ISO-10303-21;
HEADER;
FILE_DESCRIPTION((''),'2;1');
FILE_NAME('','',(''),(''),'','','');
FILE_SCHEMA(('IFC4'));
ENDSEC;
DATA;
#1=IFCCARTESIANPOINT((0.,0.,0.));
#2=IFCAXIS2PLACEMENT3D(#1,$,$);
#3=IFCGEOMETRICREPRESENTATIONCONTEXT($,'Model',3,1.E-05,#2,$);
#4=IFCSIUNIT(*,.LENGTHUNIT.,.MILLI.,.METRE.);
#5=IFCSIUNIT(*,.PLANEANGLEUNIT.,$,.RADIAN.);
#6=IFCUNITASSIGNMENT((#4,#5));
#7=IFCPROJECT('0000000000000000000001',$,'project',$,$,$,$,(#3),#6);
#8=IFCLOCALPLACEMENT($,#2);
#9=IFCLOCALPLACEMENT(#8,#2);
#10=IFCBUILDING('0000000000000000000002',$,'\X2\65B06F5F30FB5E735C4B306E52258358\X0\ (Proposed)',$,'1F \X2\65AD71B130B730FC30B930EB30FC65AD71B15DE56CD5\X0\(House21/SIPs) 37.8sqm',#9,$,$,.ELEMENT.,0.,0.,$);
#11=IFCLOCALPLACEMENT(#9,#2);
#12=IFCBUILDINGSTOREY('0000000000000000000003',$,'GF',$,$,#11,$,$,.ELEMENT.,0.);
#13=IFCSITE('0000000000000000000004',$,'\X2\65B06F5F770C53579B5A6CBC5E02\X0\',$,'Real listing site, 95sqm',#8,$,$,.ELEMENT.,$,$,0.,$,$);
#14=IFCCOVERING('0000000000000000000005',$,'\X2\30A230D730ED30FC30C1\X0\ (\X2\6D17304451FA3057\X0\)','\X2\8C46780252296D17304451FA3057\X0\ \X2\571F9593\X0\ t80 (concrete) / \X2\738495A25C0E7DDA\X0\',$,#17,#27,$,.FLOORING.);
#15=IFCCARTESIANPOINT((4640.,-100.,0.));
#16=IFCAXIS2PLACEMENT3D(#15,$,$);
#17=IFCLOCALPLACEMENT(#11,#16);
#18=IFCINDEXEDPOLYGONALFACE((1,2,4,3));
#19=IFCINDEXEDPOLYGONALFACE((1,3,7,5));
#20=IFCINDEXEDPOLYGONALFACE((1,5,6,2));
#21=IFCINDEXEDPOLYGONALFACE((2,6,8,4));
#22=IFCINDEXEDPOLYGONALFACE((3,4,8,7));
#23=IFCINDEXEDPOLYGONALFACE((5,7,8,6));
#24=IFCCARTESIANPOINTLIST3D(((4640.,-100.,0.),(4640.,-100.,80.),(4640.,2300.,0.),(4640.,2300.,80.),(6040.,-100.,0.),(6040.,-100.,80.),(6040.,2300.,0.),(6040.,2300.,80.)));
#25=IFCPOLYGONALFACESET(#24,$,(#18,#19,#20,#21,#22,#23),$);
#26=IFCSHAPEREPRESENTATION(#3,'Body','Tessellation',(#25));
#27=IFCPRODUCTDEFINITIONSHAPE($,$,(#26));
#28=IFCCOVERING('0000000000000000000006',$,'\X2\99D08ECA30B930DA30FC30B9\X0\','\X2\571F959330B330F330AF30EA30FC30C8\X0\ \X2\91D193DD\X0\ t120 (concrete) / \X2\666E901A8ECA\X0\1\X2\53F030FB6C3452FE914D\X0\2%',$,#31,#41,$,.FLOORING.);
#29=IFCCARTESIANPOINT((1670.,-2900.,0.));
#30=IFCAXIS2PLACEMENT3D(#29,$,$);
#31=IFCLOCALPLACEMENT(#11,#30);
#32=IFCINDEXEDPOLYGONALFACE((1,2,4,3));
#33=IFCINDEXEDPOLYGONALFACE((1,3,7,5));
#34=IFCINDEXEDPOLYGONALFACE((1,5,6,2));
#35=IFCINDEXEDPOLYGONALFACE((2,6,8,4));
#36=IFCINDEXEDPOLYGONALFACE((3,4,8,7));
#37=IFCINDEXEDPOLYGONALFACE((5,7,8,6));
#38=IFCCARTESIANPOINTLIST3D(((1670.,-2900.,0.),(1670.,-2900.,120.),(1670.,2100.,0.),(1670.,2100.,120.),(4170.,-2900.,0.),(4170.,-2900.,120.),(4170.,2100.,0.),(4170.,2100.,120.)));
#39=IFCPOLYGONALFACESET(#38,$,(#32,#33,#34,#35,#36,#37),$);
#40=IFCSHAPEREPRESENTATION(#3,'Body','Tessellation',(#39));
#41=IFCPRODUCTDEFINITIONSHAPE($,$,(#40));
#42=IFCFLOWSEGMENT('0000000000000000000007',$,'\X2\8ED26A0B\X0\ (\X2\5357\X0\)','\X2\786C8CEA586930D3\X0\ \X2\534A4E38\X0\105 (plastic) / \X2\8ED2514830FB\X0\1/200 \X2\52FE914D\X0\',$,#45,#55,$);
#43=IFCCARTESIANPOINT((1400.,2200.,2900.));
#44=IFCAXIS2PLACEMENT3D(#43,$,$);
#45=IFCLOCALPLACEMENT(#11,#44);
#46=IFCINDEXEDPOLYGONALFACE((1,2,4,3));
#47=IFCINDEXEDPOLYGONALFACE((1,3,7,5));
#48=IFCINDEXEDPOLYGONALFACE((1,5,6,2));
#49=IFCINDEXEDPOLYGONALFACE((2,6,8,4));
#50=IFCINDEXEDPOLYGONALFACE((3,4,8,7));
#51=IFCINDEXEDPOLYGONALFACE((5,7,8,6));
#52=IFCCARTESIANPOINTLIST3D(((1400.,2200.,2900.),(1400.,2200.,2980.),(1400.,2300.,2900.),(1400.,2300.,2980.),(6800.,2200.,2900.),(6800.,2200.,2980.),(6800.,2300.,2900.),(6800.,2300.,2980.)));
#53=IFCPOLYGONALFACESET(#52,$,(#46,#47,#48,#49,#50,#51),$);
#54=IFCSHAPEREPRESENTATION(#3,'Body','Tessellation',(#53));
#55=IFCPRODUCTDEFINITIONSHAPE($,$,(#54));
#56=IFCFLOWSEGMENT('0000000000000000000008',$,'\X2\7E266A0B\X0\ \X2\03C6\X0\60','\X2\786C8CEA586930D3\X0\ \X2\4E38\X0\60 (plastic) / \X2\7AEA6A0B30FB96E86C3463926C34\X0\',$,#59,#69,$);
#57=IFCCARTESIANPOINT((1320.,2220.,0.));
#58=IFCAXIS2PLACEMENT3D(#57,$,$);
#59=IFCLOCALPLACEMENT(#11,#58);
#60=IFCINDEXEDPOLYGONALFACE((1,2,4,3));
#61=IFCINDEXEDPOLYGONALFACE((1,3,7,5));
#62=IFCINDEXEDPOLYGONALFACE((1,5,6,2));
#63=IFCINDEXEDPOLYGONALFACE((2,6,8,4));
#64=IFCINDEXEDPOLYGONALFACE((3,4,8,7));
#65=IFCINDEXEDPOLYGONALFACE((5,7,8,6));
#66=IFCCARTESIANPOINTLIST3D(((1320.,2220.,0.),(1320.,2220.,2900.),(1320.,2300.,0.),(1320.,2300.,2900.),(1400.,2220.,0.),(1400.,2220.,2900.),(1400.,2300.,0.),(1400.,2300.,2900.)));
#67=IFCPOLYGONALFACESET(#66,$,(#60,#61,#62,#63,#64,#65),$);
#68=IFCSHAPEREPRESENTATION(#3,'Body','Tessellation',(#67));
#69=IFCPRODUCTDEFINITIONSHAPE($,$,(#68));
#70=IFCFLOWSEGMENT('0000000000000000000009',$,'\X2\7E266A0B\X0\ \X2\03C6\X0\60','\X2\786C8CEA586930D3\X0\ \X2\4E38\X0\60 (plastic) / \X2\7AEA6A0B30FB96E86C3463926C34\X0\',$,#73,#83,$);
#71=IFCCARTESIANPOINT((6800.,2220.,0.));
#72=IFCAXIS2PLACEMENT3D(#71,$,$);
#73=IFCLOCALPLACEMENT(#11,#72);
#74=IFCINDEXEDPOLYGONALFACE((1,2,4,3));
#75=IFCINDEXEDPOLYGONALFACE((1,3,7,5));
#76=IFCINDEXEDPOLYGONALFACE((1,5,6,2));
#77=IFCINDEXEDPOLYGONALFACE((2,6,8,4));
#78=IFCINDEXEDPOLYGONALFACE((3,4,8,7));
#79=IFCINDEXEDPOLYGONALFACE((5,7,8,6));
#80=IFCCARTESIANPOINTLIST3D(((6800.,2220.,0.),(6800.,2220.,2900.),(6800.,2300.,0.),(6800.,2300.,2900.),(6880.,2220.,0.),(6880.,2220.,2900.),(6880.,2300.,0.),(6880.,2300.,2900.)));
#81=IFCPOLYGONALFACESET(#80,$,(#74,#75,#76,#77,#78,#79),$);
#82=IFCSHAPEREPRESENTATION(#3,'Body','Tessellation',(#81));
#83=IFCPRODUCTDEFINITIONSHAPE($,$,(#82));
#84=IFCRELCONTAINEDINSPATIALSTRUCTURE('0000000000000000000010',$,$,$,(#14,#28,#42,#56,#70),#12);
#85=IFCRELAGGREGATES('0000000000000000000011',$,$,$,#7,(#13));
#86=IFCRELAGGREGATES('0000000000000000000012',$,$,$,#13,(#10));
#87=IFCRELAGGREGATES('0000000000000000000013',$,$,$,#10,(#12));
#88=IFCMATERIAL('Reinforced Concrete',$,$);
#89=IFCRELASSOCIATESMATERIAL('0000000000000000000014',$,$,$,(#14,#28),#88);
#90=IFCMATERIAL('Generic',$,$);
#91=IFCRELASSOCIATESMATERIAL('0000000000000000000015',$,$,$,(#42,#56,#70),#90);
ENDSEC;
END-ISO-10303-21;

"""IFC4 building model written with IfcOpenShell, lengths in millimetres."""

from ifc_helpers import new_model, si_unit, frame, frame_2d, origin, place, context, project, spatial, rectangle, extrude, material, element, save


model = new_model("IFC4")

# Units and contexts
model_context = context("Model", 3, precision=1e-05, world=origin())
ifc_project = project(units=[si_unit("LENGTHUNIT", "METRE", prefix="MILLI"), si_unit("PLANEANGLEUNIT", "RADIAN")], contexts=[model_context])

# Site, building, storey
site_placement = place(None, origin())
site = spatial("IfcSite", under=ifc_project, at=site_placement, Name="新潟県南魚沼市", ObjectType="Real listing site, 95sqm", CompositionType="ELEMENT", RefElevation=0.0)
building_placement = place(site_placement, origin())
building = spatial("IfcBuilding", under=site, at=building_placement, Name="新潟・平屋の別荘 (Proposed)", ObjectType="1F 断熱シースルー断熱工法(House21/SIPs) 37.8sqm", CompositionType="ELEMENT", ElevationOfRefHeight=0.0, ElevationOfTerrain=0.0)
storey_placement = place(building_placement, origin())
storey = spatial("IfcBuildingStorey", under=building, at=storey_placement, Name="GF", CompositionType="ELEMENT", Elevation=0.0)

# Shared definitions
ifc_material_1 = material(Name="Reinforced Concrete")

# Coverings
covering_1_placement = place(storey_placement, frame((4640.0, -100.0, 0.0)))
element("IfcCovering", 1, at=covering_1_placement, inside=storey, material=ifc_material_1, Name="アプローチ (洗い出し)", Description="豆砂利洗い出し 土間 t80 (concrete) / 玄関導線", PredefinedType="FLOORING", context=model_context, shape_type="SweptSolid", body=[
    extrude(rectangle(XDim=1400.0, YDim=2400.0, at=frame_2d((700.0, 1200.0))), frame((4640.0, -100.0, 0.0)), (0.0, 0.0, 1.0), 80.0),
])
covering_2_placement = place(storey_placement, frame((1670.0, -2900.0, 0.0)))
element("IfcCovering", 2, at=covering_2_placement, inside=storey, material=ifc_material_1, Name="駐車スペース", Description="土間コンクリート 金鏝 t120 (concrete) / 普通車1台・水勾配2%", PredefinedType="FLOORING", context=model_context, shape_type="SweptSolid", body=[
    extrude(rectangle(XDim=2500.0, YDim=5000.0, at=frame_2d((1250.0, 2500.0))), frame((1670.0, -2900.0, 0.0)), (0.0, 0.0, 1.0), 120.0),
])

# Flow segments
ifc_material_2 = material(Name="Generic")
flow_segment_1_placement = place(storey_placement, frame((1400.0, 2200.0, 2900.0)))
element("IfcFlowSegment", 3, at=flow_segment_1_placement, inside=storey, material=ifc_material_2, Name="軒樋 (南)", Description="硬質塩ビ 半丸105 (plastic) / 軒先・1/200 勾配", context=model_context, shape_type="SweptSolid", body=[
    extrude(rectangle(XDim=5400.0, YDim=100.0, at=frame_2d((2700.0, 50.0))), frame((1400.0, 2200.0, 2900.0)), (0.0, 0.0, 1.0), 80.0),
])
flow_segment_2_placement = place(storey_placement, frame((1320.0, 2220.0, 0.0)))
element("IfcFlowSegment", 4, at=flow_segment_2_placement, inside=storey, material=ifc_material_2, Name="縦樋 φ60", Description="硬質塩ビ 丸60 (plastic) / 竪樋・雨水排水", context=model_context, shape_type="SweptSolid", body=[
    extrude(rectangle(XDim=80.0, YDim=80.0, at=frame_2d((40.0, 40.0))), frame((1320.0, 2220.0, 0.0)), (0.0, 0.0, 1.0), 2900.0),
])
flow_segment_3_placement = place(storey_placement, frame((6800.0, 2220.0, 0.0)))
element("IfcFlowSegment", 5, at=flow_segment_3_placement, inside=storey, material=ifc_material_2, Name="縦樋 φ60", Description="硬質塩ビ 丸60 (plastic) / 竪樋・雨水排水", context=model_context, shape_type="SweptSolid", body=[
    extrude(rectangle(XDim=80.0, YDim=80.0, at=frame_2d((40.0, 40.0))), frame((6800.0, 2220.0, 0.0)), (0.0, 0.0, 1.0), 2900.0),
])

save(model, "model.ifc")
